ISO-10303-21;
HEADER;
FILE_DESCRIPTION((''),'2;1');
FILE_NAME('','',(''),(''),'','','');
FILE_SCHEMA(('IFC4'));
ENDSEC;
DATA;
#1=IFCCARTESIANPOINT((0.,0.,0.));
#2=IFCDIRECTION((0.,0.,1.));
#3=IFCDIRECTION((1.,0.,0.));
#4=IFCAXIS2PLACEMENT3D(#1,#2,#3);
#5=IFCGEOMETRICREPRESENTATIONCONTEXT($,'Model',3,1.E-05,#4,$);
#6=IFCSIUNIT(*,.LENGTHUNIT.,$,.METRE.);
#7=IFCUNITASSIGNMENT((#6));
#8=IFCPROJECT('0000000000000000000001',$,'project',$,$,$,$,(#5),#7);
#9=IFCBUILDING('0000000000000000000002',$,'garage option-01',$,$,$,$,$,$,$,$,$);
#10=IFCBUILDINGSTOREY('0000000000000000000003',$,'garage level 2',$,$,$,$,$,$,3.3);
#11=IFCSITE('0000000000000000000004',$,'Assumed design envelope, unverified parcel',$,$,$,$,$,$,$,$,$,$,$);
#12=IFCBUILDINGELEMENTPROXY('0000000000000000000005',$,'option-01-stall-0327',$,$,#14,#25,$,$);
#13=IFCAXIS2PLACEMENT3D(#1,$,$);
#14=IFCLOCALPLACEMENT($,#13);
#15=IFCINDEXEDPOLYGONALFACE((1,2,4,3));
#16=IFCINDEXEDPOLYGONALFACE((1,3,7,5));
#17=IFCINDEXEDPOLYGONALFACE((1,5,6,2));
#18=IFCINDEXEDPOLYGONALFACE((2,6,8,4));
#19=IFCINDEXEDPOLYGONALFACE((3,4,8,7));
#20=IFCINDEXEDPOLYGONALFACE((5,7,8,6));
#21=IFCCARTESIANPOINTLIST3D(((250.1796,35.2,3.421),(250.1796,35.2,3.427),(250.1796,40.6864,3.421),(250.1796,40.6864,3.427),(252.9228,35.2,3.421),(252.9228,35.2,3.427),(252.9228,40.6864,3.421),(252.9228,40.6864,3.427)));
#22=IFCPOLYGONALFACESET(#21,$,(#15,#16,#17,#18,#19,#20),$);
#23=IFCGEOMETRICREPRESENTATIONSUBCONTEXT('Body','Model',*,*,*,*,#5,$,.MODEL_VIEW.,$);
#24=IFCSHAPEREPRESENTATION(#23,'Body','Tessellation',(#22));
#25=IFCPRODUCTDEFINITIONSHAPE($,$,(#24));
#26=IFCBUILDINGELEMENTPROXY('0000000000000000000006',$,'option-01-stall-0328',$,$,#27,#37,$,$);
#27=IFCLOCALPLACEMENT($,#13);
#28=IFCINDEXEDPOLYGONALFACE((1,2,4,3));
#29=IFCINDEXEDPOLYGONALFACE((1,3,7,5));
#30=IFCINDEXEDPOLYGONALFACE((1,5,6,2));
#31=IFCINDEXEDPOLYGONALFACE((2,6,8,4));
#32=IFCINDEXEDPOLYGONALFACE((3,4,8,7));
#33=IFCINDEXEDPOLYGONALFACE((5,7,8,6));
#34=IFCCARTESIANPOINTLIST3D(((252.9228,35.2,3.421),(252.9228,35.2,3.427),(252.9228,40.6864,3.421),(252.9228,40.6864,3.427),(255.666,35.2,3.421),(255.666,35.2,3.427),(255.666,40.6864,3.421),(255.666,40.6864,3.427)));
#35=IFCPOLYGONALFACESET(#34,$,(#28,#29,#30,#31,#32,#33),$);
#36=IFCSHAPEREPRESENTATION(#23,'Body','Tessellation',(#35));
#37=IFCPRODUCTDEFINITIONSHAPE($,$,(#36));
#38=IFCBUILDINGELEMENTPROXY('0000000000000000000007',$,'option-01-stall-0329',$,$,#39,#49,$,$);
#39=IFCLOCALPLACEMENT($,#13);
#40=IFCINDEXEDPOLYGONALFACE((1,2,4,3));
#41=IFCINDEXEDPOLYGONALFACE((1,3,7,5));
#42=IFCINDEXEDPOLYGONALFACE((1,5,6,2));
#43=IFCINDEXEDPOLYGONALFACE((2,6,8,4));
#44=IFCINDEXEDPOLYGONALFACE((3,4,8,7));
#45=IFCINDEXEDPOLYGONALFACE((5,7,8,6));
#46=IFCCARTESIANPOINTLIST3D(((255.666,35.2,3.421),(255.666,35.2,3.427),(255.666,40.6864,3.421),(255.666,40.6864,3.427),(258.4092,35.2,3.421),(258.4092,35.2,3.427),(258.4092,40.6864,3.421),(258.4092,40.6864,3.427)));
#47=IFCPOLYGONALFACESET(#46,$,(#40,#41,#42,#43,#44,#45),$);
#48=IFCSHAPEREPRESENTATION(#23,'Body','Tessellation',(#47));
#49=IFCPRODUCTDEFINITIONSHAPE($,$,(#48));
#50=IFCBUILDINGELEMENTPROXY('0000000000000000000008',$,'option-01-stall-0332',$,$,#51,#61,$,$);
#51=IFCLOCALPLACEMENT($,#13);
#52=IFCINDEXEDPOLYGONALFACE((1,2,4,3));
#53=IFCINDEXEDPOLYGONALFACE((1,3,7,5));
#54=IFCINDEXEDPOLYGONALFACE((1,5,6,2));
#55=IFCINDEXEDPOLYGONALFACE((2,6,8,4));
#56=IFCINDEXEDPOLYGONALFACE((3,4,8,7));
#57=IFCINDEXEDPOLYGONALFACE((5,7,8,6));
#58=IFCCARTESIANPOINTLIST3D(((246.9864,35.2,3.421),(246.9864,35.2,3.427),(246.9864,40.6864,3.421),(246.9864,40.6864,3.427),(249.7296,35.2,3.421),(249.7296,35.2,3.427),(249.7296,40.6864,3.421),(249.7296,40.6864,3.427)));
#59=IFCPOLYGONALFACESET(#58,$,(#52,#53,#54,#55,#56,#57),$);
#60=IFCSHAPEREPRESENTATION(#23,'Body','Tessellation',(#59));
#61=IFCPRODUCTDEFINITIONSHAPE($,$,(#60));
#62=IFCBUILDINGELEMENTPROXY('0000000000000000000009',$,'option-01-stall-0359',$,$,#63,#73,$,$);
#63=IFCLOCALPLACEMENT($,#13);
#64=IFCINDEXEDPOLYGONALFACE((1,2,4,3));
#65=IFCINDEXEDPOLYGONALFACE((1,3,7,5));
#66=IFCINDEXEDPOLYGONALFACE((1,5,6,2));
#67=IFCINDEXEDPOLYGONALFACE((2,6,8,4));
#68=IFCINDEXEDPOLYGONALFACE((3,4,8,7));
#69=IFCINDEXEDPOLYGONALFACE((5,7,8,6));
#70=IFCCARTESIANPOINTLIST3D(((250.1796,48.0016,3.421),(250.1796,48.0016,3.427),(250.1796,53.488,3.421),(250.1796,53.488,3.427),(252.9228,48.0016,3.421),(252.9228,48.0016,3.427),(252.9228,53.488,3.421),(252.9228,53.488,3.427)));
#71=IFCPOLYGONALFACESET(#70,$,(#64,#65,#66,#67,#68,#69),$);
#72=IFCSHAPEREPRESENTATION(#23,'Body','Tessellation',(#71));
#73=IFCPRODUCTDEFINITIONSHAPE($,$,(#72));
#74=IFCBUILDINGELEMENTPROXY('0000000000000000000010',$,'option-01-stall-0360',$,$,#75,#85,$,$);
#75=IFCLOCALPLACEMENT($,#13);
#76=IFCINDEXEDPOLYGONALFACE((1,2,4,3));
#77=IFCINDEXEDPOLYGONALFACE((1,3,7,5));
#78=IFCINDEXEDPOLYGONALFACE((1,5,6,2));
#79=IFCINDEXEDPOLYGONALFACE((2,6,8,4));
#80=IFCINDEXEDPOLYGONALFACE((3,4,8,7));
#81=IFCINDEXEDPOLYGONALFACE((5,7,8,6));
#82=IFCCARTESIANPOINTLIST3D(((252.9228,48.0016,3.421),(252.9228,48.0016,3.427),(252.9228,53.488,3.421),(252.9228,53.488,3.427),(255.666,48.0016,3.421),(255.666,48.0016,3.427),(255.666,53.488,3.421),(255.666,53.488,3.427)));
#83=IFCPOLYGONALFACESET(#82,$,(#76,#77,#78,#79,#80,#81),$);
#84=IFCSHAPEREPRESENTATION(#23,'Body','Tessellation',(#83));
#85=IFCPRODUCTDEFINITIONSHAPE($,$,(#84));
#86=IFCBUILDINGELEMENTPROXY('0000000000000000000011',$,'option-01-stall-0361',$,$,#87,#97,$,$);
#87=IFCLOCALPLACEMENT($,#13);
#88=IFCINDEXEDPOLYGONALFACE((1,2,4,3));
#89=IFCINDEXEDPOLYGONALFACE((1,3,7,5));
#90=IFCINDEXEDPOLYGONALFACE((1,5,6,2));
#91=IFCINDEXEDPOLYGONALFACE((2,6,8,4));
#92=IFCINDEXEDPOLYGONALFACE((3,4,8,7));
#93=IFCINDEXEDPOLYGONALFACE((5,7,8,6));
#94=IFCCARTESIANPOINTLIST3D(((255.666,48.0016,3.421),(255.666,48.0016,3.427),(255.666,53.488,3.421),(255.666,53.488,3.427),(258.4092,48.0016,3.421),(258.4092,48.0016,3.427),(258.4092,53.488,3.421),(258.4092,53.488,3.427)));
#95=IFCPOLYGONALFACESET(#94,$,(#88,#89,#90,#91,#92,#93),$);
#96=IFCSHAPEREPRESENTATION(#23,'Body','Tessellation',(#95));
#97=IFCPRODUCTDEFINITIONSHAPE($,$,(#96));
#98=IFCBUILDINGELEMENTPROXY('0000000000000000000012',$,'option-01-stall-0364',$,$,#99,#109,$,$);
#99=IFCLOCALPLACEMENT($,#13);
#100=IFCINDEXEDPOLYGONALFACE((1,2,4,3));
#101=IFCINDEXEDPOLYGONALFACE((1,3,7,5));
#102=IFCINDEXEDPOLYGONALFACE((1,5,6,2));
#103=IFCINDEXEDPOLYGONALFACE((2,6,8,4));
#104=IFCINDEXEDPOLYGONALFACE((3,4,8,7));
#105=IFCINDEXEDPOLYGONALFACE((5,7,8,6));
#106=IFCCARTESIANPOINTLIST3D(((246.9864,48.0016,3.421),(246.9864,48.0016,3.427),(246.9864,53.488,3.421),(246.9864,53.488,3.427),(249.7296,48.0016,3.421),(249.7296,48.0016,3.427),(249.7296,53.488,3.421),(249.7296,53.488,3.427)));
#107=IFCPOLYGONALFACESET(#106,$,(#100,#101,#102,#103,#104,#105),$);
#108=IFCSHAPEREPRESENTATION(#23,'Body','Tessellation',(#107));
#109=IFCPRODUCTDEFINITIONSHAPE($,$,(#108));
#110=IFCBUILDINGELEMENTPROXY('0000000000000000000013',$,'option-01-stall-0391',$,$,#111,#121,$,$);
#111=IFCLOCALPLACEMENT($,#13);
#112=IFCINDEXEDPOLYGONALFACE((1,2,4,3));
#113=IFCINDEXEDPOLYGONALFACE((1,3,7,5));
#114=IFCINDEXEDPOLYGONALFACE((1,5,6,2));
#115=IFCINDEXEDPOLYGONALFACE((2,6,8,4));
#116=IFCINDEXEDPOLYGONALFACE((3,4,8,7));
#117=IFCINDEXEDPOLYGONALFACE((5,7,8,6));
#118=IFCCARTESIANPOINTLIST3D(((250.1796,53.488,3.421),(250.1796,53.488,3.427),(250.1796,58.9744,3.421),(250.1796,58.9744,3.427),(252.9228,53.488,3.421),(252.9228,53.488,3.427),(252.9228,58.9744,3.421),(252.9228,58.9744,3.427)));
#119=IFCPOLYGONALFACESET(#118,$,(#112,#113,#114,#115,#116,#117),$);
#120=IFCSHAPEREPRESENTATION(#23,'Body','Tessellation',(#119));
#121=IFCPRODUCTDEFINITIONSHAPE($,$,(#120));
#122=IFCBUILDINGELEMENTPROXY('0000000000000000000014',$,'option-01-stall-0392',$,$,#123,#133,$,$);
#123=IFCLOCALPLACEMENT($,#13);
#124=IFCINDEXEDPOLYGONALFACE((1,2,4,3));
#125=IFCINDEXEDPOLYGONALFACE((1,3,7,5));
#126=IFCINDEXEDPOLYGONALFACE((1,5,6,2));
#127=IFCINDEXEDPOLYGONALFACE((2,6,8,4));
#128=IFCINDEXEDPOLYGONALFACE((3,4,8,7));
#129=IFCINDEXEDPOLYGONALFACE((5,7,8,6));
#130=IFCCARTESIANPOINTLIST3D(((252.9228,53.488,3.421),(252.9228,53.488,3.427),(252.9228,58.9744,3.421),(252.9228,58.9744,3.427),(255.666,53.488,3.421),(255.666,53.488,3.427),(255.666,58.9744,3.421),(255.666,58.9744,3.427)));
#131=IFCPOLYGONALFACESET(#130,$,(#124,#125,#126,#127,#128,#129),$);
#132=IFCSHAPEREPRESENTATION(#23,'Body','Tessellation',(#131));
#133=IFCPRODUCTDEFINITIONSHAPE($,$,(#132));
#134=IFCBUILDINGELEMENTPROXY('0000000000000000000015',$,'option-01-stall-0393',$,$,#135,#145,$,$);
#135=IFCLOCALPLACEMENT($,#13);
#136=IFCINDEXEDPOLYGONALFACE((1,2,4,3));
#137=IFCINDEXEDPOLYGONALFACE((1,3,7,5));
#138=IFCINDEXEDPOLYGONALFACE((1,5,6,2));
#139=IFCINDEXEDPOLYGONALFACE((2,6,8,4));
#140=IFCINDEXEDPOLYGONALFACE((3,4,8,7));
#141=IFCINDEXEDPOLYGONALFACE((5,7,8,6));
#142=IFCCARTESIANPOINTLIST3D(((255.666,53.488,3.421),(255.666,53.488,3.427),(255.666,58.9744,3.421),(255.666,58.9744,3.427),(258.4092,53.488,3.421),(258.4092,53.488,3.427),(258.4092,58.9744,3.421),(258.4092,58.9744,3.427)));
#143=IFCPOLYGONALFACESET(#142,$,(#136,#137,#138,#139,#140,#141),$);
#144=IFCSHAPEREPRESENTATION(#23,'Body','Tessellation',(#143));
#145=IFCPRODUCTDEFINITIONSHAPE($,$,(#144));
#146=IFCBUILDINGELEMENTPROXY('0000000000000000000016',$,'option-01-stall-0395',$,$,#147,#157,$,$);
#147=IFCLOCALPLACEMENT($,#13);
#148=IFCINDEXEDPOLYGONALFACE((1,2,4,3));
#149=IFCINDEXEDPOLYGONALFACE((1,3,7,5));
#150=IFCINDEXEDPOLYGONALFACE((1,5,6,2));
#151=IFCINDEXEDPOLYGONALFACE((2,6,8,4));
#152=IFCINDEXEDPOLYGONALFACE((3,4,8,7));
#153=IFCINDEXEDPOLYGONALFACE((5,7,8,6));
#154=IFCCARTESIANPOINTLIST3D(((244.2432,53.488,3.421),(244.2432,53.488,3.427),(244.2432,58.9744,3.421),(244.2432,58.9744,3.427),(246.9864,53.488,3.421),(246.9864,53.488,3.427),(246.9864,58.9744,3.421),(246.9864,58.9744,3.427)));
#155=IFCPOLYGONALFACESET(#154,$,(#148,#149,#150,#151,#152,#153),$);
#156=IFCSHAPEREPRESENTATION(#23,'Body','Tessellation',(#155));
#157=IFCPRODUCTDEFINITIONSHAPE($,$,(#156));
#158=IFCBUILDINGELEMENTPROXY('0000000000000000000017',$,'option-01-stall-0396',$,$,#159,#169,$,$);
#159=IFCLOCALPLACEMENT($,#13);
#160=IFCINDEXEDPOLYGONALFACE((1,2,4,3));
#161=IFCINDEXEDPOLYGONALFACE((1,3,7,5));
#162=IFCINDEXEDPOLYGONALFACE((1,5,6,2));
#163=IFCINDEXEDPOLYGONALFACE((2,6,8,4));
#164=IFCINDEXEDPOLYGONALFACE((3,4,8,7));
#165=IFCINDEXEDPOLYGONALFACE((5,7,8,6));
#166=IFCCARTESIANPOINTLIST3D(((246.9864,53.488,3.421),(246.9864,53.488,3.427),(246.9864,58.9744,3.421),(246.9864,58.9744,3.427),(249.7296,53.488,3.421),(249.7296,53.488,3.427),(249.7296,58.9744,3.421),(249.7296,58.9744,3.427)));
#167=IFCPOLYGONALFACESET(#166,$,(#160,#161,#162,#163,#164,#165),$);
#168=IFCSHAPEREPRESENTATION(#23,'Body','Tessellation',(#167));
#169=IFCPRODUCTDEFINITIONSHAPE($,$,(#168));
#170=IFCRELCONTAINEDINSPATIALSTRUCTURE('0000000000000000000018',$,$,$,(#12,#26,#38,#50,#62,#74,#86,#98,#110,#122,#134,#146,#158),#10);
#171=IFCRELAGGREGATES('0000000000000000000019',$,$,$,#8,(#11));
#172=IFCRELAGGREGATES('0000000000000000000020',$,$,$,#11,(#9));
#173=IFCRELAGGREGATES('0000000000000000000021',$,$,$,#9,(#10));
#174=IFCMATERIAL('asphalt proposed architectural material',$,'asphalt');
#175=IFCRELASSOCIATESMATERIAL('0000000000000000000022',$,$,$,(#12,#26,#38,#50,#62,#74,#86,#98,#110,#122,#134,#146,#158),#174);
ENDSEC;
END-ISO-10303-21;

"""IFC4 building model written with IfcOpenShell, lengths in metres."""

from ifc_helpers import new_model, si_unit, frame, origin_with_axes, place, context, subcontext, project, spatial, rectangle, extrude, material, element, save


model = new_model("IFC4")

# Units and contexts
model_context = context("Model", 3, precision=1e-05, world=origin_with_axes())
body_context = subcontext(model_context, "Body", "Model", "MODEL_VIEW")
ifc_project = project(units=[si_unit("LENGTHUNIT", "METRE")], contexts=[model_context])

# Site, building, storey
site = spatial("IfcSite", under=ifc_project, Name="Assumed design envelope, unverified parcel")
building = spatial("IfcBuilding", under=site, Name="garage option-01")
storey = spatial("IfcBuildingStorey", under=building, Name="garage level 2", Elevation=3.3)

# Building element proxies
ifc_material_1 = material(Name="asphalt proposed architectural material", Category="asphalt")
for number, where, z_axis, x_axis, name in (
    (1, (251.5512, 37.9432, 3.421), (0.0, 0.0, 1.0), (1.0, 0.0, 0.0), "option-01-stall-0327"),
    (2, (254.2944, 37.9432, 3.421), (0.0, 0.0, 1.0), (1.0, 0.0, 0.0), "option-01-stall-0328"),
    (3, (257.0376, 37.9432, 3.421), (0.0, 0.0, 1.0), (1.0, 0.0, 0.0), "option-01-stall-0329"),
    (4, (248.358, 37.9432, 3.421), (0.0, 0.0, 1.0), (1.0, 0.0, 0.0), "option-01-stall-0332"),
    (5, (251.5512, 50.7448, 3.421), (0.0, 0.0, 1.0), (1.0, 0.0, 0.0), "option-01-stall-0359"),
    (6, (254.2944, 50.7448, 3.421), (0.0, 0.0, 1.0), (1.0, 0.0, 0.0), "option-01-stall-0360"),
    (7, (257.0376, 50.7448, 3.421), (0.0, 0.0, 1.0), (1.0, 0.0, 0.0), "option-01-stall-0361"),
    (8, (248.358, 50.7448, 3.421), (0.0, 0.0, 1.0), (1.0, 0.0, 0.0), "option-01-stall-0364"),
):
    element("IfcBuildingElementProxy", number, at=place(None, frame(where, z_axis=z_axis, x_axis=x_axis)), inside=storey, material=ifc_material_1, Name=name, context=body_context, shape_type="SweptSolid", body=[
        extrude(rectangle(XDim=2.7432, YDim=5.4864), origin_with_axes(), (0.0, 0.0, 1.0), 0.006),
    ])
for number, where, z_axis, x_axis, name in (
    (9, (251.5512, 56.2312, 3.421), (0.0, 0.0, 1.0), (1.0, 0.0, 0.0), "option-01-stall-0391"),
    (10, (254.2944, 56.2312, 3.421), (0.0, 0.0, 1.0), (1.0, 0.0, 0.0), "option-01-stall-0392"),
    (11, (257.0376, 56.2312, 3.421), (0.0, 0.0, 1.0), (1.0, 0.0, 0.0), "option-01-stall-0393"),
    (12, (245.6148, 56.2312, 3.421), (0.0, 0.0, 1.0), (1.0, 0.0, 0.0), "option-01-stall-0395"),
    (13, (248.358, 56.2312, 3.421), (0.0, 0.0, 1.0), (1.0, 0.0, 0.0), "option-01-stall-0396"),
):
    element("IfcBuildingElementProxy", number, at=place(None, frame(where, z_axis=z_axis, x_axis=x_axis)), inside=storey, material=ifc_material_1, Name=name, context=body_context, shape_type="SweptSolid", body=[
        extrude(rectangle(XDim=2.7432, YDim=5.4864), origin_with_axes(), (0.0, 0.0, 1.0), 0.006),
    ])

save(model, "model.ifc")
